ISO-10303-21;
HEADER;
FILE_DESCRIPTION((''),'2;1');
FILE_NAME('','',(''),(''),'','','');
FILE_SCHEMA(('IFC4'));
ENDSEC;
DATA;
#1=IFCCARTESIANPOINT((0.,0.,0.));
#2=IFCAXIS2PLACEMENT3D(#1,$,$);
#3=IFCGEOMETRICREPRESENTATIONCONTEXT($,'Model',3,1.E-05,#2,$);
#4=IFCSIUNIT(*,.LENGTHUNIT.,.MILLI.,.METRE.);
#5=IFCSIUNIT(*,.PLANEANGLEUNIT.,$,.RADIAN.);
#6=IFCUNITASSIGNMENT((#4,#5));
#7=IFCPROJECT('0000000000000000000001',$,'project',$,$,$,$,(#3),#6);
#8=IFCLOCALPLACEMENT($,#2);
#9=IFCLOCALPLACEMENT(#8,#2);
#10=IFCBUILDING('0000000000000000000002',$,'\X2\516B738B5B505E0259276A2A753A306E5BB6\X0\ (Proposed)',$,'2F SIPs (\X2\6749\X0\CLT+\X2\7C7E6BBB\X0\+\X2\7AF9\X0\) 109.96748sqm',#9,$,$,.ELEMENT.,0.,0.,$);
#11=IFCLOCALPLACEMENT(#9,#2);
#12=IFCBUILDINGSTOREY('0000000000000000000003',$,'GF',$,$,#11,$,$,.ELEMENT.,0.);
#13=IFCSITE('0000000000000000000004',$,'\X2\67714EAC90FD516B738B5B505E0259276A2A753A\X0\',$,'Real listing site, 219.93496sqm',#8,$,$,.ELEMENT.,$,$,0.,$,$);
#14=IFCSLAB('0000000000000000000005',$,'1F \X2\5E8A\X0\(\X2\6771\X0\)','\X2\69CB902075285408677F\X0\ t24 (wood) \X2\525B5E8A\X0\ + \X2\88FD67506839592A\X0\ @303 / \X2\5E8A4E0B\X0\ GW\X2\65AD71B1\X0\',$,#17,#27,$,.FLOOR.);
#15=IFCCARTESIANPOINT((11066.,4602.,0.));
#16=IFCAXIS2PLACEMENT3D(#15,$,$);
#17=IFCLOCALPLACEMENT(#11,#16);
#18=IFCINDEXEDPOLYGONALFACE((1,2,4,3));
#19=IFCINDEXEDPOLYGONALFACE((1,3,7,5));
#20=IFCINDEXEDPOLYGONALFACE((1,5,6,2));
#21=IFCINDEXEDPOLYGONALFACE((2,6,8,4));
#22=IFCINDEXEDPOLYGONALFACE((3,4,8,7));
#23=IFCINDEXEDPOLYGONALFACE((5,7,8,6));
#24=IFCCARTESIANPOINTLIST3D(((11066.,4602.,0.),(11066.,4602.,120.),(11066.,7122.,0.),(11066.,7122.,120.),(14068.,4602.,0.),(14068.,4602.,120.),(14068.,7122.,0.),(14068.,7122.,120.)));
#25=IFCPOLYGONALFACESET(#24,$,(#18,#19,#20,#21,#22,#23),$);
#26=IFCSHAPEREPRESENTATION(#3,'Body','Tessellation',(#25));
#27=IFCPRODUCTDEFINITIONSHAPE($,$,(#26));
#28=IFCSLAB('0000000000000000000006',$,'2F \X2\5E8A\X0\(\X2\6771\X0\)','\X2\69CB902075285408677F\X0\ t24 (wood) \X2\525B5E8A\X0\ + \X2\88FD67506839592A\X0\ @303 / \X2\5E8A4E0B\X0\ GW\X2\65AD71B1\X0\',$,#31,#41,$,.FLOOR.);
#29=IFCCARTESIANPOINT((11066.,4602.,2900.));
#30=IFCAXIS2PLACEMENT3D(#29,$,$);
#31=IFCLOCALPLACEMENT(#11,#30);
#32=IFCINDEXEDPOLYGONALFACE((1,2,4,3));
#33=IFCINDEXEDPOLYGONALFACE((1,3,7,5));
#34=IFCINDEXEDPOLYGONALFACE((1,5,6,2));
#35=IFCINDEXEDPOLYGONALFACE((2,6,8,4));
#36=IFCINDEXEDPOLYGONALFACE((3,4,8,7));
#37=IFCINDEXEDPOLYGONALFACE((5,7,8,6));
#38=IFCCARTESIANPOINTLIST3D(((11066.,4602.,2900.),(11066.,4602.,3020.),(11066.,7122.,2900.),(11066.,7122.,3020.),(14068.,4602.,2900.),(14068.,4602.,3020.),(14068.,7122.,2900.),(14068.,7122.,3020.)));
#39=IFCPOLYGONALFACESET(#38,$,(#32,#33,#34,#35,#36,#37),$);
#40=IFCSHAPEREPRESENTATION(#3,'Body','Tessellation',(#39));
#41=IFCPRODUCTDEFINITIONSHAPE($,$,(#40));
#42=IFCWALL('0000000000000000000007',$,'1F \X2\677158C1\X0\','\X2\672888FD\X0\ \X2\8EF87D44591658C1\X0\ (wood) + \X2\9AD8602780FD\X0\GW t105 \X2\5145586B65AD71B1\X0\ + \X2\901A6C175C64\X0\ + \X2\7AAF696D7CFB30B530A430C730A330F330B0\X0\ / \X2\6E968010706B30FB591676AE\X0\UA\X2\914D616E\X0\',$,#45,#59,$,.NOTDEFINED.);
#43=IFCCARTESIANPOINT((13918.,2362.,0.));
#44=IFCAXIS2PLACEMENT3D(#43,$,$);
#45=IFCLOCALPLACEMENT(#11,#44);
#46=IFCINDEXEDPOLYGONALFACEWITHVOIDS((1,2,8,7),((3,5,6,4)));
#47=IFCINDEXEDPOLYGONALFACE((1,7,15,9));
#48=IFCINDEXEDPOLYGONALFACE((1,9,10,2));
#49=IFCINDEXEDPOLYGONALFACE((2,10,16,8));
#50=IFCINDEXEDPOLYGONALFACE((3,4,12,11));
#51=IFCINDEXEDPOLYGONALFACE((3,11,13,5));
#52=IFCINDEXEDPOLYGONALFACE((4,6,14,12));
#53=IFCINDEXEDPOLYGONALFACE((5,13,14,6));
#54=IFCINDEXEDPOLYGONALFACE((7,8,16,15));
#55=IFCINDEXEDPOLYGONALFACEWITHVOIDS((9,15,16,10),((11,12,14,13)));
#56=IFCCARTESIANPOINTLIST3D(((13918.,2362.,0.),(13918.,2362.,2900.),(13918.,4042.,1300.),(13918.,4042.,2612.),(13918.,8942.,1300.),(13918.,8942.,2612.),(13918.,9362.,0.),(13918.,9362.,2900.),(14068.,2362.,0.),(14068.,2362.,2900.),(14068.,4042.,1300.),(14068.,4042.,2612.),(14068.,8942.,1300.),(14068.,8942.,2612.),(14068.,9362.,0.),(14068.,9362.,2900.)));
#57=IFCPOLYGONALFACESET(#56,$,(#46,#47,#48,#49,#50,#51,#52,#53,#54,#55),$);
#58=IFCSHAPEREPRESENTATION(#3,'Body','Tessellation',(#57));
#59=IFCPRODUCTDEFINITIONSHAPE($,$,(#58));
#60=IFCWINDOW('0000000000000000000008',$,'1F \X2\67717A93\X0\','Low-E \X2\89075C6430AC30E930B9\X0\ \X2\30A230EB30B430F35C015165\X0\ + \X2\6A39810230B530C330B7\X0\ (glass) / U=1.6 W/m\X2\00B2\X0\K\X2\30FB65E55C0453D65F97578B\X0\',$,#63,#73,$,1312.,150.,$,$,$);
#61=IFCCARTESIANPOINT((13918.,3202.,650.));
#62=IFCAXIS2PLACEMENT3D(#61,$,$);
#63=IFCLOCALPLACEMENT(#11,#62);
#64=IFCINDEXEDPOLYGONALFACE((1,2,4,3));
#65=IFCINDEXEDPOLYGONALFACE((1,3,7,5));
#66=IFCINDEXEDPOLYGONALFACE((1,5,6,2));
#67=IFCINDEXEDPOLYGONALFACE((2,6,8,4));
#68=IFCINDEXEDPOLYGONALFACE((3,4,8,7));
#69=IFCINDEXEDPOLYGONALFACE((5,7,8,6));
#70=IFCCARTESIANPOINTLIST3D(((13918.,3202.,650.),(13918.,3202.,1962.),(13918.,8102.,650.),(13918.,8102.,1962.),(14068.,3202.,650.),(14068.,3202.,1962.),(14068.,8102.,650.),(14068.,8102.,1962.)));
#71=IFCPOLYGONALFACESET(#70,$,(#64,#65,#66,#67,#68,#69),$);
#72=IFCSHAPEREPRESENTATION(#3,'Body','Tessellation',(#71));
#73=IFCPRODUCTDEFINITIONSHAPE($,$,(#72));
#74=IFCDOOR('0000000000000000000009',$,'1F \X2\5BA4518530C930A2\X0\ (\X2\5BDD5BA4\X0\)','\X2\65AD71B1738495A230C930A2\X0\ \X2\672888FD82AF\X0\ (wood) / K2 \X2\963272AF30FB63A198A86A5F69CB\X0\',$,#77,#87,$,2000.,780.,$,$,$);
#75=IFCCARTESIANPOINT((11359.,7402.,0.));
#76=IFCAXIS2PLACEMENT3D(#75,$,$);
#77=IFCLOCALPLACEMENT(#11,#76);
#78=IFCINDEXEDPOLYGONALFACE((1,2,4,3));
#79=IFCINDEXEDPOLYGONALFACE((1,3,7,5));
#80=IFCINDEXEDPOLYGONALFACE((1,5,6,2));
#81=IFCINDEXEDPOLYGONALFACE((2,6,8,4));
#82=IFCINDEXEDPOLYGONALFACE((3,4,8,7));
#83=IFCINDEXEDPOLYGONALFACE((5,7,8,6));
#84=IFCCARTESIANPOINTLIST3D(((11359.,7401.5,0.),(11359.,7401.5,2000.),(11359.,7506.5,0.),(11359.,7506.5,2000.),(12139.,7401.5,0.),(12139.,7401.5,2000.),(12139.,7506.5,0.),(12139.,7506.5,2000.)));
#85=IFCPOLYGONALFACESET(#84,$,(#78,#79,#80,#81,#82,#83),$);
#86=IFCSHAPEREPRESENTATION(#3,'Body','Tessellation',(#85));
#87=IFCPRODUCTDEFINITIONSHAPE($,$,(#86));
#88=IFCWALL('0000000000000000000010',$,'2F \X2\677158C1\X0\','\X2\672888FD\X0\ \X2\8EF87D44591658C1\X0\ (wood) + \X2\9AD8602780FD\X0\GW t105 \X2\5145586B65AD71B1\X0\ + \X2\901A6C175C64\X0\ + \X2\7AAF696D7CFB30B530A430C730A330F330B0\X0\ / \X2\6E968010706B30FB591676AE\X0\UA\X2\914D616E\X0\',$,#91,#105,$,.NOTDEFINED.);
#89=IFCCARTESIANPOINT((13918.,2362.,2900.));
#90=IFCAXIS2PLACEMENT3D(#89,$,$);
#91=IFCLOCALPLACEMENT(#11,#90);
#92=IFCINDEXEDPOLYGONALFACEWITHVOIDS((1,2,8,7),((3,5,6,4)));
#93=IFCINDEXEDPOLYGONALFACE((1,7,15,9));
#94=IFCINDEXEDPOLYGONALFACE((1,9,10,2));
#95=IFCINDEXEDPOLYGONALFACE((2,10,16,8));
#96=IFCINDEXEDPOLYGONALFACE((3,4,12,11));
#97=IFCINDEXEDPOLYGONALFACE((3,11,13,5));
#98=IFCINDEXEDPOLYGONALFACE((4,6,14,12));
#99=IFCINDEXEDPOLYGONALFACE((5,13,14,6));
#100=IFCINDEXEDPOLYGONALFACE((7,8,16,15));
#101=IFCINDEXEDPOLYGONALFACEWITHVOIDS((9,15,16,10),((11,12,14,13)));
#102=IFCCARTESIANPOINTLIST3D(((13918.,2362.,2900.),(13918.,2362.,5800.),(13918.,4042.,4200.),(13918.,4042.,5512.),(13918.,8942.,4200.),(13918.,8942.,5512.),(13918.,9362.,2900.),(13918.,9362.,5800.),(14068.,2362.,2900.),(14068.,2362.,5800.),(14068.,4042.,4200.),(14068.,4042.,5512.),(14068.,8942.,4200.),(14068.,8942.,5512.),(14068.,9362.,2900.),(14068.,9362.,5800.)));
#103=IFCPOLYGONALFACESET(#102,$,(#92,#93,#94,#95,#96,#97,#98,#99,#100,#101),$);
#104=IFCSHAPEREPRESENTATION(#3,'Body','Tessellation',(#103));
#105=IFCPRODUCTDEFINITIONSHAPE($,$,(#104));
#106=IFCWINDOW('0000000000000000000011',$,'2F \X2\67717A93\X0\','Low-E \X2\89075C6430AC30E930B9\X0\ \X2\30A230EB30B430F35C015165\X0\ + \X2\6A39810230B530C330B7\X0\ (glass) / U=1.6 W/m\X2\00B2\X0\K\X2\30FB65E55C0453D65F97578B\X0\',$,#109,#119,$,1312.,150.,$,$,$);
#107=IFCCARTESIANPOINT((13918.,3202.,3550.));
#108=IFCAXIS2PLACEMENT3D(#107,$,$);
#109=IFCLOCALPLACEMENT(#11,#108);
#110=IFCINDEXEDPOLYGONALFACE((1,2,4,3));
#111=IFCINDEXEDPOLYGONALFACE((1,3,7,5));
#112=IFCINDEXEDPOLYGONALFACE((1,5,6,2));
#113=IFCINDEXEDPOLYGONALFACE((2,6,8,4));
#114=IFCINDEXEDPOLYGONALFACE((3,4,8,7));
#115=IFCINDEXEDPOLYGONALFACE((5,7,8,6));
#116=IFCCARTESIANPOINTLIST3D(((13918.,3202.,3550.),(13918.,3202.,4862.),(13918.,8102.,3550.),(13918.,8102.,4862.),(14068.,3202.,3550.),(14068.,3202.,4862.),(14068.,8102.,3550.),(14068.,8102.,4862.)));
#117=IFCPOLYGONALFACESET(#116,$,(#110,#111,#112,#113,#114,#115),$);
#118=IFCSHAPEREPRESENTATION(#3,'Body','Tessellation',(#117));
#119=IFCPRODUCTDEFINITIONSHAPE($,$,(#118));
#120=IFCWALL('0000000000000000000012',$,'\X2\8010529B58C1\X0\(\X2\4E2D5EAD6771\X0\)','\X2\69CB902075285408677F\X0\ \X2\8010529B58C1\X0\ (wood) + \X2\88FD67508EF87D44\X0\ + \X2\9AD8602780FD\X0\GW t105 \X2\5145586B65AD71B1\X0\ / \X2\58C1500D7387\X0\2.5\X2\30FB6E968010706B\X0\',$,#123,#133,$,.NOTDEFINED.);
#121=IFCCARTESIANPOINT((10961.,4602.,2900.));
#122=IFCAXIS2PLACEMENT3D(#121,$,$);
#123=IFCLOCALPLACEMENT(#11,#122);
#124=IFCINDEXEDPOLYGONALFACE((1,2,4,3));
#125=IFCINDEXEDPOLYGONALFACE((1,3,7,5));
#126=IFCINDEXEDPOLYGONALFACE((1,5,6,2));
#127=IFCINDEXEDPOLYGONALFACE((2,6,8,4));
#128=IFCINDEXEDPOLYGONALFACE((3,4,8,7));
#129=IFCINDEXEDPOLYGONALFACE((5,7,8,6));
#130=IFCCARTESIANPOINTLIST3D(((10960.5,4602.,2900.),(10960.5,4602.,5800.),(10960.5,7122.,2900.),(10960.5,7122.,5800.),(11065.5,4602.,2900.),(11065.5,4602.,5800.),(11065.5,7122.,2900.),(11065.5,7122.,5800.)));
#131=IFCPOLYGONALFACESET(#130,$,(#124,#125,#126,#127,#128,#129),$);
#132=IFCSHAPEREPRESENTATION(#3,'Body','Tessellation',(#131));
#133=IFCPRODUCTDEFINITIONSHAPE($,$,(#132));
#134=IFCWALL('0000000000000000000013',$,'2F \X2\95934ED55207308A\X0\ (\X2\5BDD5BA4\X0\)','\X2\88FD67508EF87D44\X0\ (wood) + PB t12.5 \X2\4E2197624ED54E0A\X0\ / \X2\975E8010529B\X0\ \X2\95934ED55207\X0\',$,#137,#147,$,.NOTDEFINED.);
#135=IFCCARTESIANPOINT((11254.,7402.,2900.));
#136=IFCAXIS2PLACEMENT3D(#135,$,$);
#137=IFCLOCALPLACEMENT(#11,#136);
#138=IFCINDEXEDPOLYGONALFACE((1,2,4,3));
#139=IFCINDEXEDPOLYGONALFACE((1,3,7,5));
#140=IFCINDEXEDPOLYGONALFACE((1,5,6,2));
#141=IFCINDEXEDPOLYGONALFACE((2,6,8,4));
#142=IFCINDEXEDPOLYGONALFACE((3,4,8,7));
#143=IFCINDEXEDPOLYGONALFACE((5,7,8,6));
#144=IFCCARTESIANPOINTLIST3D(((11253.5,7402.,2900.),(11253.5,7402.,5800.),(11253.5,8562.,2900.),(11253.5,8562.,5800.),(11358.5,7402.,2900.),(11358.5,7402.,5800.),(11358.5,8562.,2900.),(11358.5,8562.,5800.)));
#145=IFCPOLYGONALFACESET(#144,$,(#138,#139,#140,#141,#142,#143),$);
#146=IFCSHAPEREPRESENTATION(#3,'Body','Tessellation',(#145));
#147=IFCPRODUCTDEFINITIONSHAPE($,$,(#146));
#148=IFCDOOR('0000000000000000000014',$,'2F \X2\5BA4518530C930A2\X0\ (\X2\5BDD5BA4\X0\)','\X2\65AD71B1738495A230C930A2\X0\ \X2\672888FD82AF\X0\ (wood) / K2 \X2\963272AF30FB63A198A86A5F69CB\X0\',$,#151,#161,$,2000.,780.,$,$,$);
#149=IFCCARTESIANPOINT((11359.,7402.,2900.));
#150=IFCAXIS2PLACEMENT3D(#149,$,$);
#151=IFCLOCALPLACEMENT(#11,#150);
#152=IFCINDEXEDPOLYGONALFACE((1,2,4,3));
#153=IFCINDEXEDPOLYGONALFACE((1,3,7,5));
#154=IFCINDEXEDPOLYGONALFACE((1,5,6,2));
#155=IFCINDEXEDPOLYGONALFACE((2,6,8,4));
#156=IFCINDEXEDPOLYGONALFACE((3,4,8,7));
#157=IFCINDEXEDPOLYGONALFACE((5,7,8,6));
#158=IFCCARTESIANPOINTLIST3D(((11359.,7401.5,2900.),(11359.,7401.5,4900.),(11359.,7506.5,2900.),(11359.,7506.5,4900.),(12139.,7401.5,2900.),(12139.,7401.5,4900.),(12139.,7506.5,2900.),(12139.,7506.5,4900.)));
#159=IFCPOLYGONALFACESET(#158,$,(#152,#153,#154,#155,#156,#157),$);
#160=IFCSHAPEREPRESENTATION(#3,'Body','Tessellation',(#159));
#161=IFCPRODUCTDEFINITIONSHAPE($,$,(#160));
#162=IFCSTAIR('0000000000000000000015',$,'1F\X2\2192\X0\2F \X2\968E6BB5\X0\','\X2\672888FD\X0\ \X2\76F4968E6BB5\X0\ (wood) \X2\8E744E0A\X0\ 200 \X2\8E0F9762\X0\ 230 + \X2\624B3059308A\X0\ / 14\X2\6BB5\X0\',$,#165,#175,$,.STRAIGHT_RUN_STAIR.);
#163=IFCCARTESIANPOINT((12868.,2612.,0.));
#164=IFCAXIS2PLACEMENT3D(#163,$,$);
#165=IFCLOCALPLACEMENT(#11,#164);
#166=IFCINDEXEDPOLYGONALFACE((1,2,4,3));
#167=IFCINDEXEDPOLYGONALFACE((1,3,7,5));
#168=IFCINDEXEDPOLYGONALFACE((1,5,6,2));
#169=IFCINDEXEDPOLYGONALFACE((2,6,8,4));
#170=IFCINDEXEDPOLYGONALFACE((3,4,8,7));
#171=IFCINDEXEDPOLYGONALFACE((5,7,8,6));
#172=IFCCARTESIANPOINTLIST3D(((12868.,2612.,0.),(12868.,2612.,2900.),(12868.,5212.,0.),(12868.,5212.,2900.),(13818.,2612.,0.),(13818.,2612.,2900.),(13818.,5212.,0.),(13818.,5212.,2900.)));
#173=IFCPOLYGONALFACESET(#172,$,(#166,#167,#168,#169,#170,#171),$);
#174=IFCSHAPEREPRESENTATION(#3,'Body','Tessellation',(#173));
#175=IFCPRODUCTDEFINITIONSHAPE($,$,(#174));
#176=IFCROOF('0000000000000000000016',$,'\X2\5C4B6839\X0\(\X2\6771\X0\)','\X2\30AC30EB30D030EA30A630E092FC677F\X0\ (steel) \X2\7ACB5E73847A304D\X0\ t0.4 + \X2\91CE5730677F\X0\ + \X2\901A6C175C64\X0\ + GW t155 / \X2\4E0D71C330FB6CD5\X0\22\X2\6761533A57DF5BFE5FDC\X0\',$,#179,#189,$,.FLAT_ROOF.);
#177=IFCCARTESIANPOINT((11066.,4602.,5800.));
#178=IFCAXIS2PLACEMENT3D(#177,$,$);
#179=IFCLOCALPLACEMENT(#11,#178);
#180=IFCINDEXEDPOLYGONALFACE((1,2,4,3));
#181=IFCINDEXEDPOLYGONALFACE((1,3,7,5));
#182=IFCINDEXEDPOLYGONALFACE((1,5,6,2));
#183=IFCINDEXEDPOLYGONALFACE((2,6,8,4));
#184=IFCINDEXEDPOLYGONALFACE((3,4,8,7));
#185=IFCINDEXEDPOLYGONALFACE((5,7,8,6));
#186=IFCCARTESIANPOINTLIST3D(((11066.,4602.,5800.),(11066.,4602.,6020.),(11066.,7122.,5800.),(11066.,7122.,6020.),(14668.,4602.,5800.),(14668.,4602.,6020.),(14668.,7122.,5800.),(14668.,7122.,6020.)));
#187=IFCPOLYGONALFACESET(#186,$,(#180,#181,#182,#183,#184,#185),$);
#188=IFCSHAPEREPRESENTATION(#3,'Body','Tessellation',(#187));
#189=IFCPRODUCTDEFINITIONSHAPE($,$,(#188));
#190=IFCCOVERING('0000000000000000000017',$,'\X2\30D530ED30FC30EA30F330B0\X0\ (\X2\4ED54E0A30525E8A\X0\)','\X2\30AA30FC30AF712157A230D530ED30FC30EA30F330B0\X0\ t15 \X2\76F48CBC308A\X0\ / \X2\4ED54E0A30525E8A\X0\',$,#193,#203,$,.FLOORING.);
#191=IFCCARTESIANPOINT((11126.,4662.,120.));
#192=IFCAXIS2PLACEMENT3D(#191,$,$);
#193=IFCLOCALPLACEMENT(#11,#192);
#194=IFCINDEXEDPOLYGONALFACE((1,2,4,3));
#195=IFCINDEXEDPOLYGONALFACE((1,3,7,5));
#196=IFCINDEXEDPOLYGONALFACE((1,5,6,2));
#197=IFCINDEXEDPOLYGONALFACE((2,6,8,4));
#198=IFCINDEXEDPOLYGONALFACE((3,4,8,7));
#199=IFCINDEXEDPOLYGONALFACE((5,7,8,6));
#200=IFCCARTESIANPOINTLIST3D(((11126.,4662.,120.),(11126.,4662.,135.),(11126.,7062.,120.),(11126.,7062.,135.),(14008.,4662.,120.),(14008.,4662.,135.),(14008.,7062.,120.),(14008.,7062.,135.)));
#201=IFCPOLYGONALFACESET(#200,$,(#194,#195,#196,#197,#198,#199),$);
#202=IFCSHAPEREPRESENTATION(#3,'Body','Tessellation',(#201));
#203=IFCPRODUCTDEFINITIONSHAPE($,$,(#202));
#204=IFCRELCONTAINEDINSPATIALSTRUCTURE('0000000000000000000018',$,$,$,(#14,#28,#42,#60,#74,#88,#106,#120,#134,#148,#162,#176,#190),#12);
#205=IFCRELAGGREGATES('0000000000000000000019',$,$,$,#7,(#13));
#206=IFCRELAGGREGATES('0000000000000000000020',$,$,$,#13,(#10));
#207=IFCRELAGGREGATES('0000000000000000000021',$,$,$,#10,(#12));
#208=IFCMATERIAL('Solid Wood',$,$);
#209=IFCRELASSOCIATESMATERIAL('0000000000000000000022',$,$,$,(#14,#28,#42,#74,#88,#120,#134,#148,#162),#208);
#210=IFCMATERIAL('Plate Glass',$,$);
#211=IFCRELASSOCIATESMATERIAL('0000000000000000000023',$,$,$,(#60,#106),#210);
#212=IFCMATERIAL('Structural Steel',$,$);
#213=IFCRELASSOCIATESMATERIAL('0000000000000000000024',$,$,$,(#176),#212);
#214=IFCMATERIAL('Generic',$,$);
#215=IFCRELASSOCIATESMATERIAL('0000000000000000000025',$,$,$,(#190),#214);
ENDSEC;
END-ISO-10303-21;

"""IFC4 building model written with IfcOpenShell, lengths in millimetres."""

from ifc_helpers import new_model, si_unit, frame, frame_2d, origin, place, context, project, spatial, rectangle, extrude, material, element, fill, save


model = new_model("IFC4")

# Units and contexts
model_context = context("Model", 3, precision=1e-05, world=origin())
ifc_project = project(units=[si_unit("LENGTHUNIT", "METRE", prefix="MILLI"), si_unit("PLANEANGLEUNIT", "RADIAN")], contexts=[model_context])

# Site, building, storey
site_placement = place(None, origin())
site = spatial("IfcSite", under=ifc_project, at=site_placement, Name="東京都八王子市大横町", ObjectType="Real listing site, 219.93496sqm", CompositionType="ELEMENT", RefElevation=0.0)
building_placement = place(site_placement, origin())
building = spatial("IfcBuilding", under=site, at=building_placement, Name="八王子市大横町の家 (Proposed)", ObjectType="2F SIPs (杉CLT+籾殻+竹) 109.96748sqm", CompositionType="ELEMENT", ElevationOfRefHeight=0.0, ElevationOfTerrain=0.0)
storey_placement = place(building_placement, origin())
storey = spatial("IfcBuildingStorey", under=building, at=storey_placement, Name="GF", CompositionType="ELEMENT", Elevation=0.0)

# Slabs
ifc_material_1 = material(Name="Solid Wood")
slab_1_placement = place(storey_placement, frame((11066.0, 4602.0, 0.0)))
element("IfcSlab", 1, at=slab_1_placement, inside=storey, material=ifc_material_1, Name="1F 床(東)", Description="構造用合板 t24 (wood) 剛床 + 製材根太 @303 / 床下 GW断熱", PredefinedType="FLOOR", context=model_context, shape_type="SweptSolid", body=[
    extrude(rectangle(XDim=3002.0, YDim=2520.0, at=frame_2d((1501.0, 1260.0))), frame((11066.0, 4602.0, 0.0)), (0.0, 0.0, 1.0), 120.0),
])
slab_2_placement = place(storey_placement, frame((11066.0, 4602.0, 2900.0)))
element("IfcSlab", 2, at=slab_2_placement, inside=storey, material=ifc_material_1, Name="2F 床(東)", Description="構造用合板 t24 (wood) 剛床 + 製材根太 @303 / 床下 GW断熱", PredefinedType="FLOOR", context=model_context, shape_type="SweptSolid", body=[
    extrude(rectangle(XDim=3002.0, YDim=2520.0, at=frame_2d((1501.0, 1260.0))), frame((11066.0, 4602.0, 2900.0)), (0.0, 0.0, 1.0), 120.0),
])

# Wall, opening, window
wall_1_placement = place(storey_placement, frame((13918.0, 2362.0, 0.0)))
wall_1 = element("IfcWall", 3, at=wall_1_placement, inside=storey, material=ifc_material_1, Name="1F 東壁", Description="木製 軸組外壁 (wood) + 高性能GW t105 充填断熱 + 通気層 + 窯業系サイディング / 準耐火・外皮UA配慮", PredefinedType="NOTDEFINED", context=model_context, shape_type="SweptSolid", body=[
    extrude(rectangle(XDim=150.0, YDim=7000.0, at=frame_2d((75.0, 3500.0))), frame((13918.0, 2362.0, 0.0)), (0.0, 0.0, 1.0), 2900.0),
])
opening_1_placement = place(storey_placement, frame((13918.0, 3202.0, 650.0)))
opening_1 = element("IfcOpeningElement", 4, at=opening_1_placement, cuts=wall_1, PredefinedType="NOTDEFINED", context=model_context, shape_type="SweptSolid", body=[
    extrude(rectangle(XDim=150.0, YDim=4900.0, at=frame_2d((75.0, 2450.0))), frame((13918.0, 3202.0, 650.0)), (0.0, 0.0, 1.0), 1312.0),
])
ifc_material_2 = material(Name="Plate Glass")
window_1_placement = place(storey_placement, frame((13918.0, 3202.0, 650.0)))
window_1 = element("IfcWindow", 5, at=window_1_placement, inside=storey, material=ifc_material_2, Name="1F 東窓", Description="Low-E 複層ガラス アルゴン封入 + 樹脂サッシ (glass) / U=1.6 W/m²K・日射取得型", OverallHeight=1312.0, OverallWidth=150.0, context=model_context, shape_type="SweptSolid", body=[
    extrude(rectangle(XDim=150.0, YDim=4900.0, at=frame_2d((75.0, 2450.0))), frame((13918.0, 3202.0, 650.0)), (0.0, 0.0, 1.0), 1312.0),
])
fill(opening_1, window_1)

# Door
door_1_placement = place(storey_placement, frame((11359.0, 7402.0, 0.0)))
element("IfcDoor", 6, at=door_1_placement, inside=storey, material=ifc_material_1, Name="1F 室内ドア (寝室)", Description="断熱玄関ドア 木製芯 (wood) / K2 防犯・採風機構", OverallHeight=2000.0, OverallWidth=780.0, context=model_context, shape_type="SweptSolid", body=[
    extrude(rectangle(XDim=780.0, YDim=105.0, at=frame_2d((390.0, 52.0))), frame((11359.0, 7402.0, 0.0)), (0.0, 0.0, 1.0), 2000.0),
])

# Wall, opening, window
wall_2_placement = place(storey_placement, frame((13918.0, 2362.0, 2900.0)))
wall_2 = element("IfcWall", 7, at=wall_2_placement, inside=storey, material=ifc_material_1, Name="2F 東壁", Description="木製 軸組外壁 (wood) + 高性能GW t105 充填断熱 + 通気層 + 窯業系サイディング / 準耐火・外皮UA配慮", PredefinedType="NOTDEFINED", context=model_context, shape_type="SweptSolid", body=[
    extrude(rectangle(XDim=150.0, YDim=7000.0, at=frame_2d((75.0, 3500.0))), frame((13918.0, 2362.0, 2900.0)), (0.0, 0.0, 1.0), 2900.0),
])
opening_2_placement = place(storey_placement, frame((13918.0, 3202.0, 3550.0)))
opening_2 = element("IfcOpeningElement", 8, at=opening_2_placement, cuts=wall_2, PredefinedType="NOTDEFINED", context=model_context, shape_type="SweptSolid", body=[
    extrude(rectangle(XDim=150.0, YDim=4900.0, at=frame_2d((75.0, 2450.0))), frame((13918.0, 3202.0, 3550.0)), (0.0, 0.0, 1.0), 1312.0),
])
window_2_placement = place(storey_placement, frame((13918.0, 3202.0, 3550.0)))
window_2 = element("IfcWindow", 9, at=window_2_placement, inside=storey, material=ifc_material_2, Name="2F 東窓", Description="Low-E 複層ガラス アルゴン封入 + 樹脂サッシ (glass) / U=1.6 W/m²K・日射取得型", OverallHeight=1312.0, OverallWidth=150.0, context=model_context, shape_type="SweptSolid", body=[
    extrude(rectangle(XDim=150.0, YDim=4900.0, at=frame_2d((75.0, 2450.0))), frame((13918.0, 3202.0, 3550.0)), (0.0, 0.0, 1.0), 1312.0),
])
fill(opening_2, window_2)

# Walls
wall_3_placement = place(storey_placement, frame((10961.0, 4602.0, 2900.0)))
element("IfcWall", 10, at=wall_3_placement, inside=storey, material=ifc_material_1, Name="耐力壁(中庭東)", Description="構造用合板 耐力壁 (wood) + 製材軸組 + 高性能GW t105 充填断熱 / 壁倍率2.5・準耐火", PredefinedType="NOTDEFINED", context=model_context, shape_type="SweptSolid", body=[
    extrude(rectangle(XDim=105.0, YDim=2520.0, at=frame_2d((52.0, 1260.0))), frame((10961.0, 4602.0, 2900.0)), (0.0, 0.0, 1.0), 2900.0),
])
wall_4_placement = place(storey_placement, frame((11254.0, 7402.0, 2900.0)))
element("IfcWall", 11, at=wall_4_placement, inside=storey, material=ifc_material_1, Name="2F 間仕切り (寝室)", Description="製材軸組 (wood) + PB t12.5 両面仕上 / 非耐力 間仕切", PredefinedType="NOTDEFINED", context=model_context, shape_type="SweptSolid", body=[
    extrude(rectangle(XDim=105.0, YDim=1160.0, at=frame_2d((52.0, 580.0))), frame((11254.0, 7402.0, 2900.0)), (0.0, 0.0, 1.0), 2900.0),
])

# Door
door_2_placement = place(storey_placement, frame((11359.0, 7402.0, 2900.0)))
element("IfcDoor", 12, at=door_2_placement, inside=storey, material=ifc_material_1, Name="2F 室内ドア (寝室)", Description="断熱玄関ドア 木製芯 (wood) / K2 防犯・採風機構", OverallHeight=2000.0, OverallWidth=780.0, context=model_context, shape_type="SweptSolid", body=[
    extrude(rectangle(XDim=780.0, YDim=105.0, at=frame_2d((390.0, 52.0))), frame((11359.0, 7402.0, 2900.0)), (0.0, 0.0, 1.0), 2000.0),
])

# Stair
stair_placement = place(storey_placement, frame((12868.0, 2612.0, 0.0)))
element("IfcStair", 13, at=stair_placement, inside=storey, material=ifc_material_1, Name="1F→2F 階段", Description="木製 直階段 (wood) 蹴上 200 踏面 230 + 手すり / 14段", PredefinedType="STRAIGHT_RUN_STAIR", context=model_context, shape_type="SweptSolid", body=[
    extrude(rectangle(XDim=950.0, YDim=2600.0, at=frame_2d((475.0, 1300.0))), frame((12868.0, 2612.0, 0.0)), (0.0, 0.0, 1.0), 2900.0),
])

# Roof
ifc_material_3 = material(Name="Structural Steel")
for number, where, name in (
    (14, (11066.0, 4602.0, 5800.0), "屋根(東)"),
):
    element("IfcRoof", number, at=place(storey_placement, frame(where)), inside=storey, material=ifc_material_3, Name=name, Description="ガルバリウム鋼板 (steel) 立平葺き t0.4 + 野地板 + 通気層 + GW t155 / 不燃・法22条区域対応", PredefinedType="FLAT_ROOF", context=model_context, shape_type="SweptSolid", body=[
        extrude(rectangle(XDim=3602.0, YDim=2520.0, at=frame_2d((1801.0, 1260.0))), frame((11066.0, 4602.0, 5800.0)), (0.0, 0.0, 1.0), 220.0),
    ])

# Covering
ifc_material_4 = material(Name="Generic")
covering_1_placement = place(storey_placement, frame((11126.0, 4662.0, 120.0)))
element("IfcCovering", 15, at=covering_1_placement, inside=storey, material=ifc_material_4, Name="フローリング (仕上げ床)", Description="オーク無垢フローリング t15 直貼り / 仕上げ床", PredefinedType="FLOORING", context=model_context, shape_type="SweptSolid", body=[
    extrude(rectangle(XDim=2882.0, YDim=2400.0, at=frame_2d((1441.0, 1200.0))), frame((11126.0, 4662.0, 120.0)), (0.0, 0.0, 1.0), 15.0),
])

save(model, "model.ifc")
